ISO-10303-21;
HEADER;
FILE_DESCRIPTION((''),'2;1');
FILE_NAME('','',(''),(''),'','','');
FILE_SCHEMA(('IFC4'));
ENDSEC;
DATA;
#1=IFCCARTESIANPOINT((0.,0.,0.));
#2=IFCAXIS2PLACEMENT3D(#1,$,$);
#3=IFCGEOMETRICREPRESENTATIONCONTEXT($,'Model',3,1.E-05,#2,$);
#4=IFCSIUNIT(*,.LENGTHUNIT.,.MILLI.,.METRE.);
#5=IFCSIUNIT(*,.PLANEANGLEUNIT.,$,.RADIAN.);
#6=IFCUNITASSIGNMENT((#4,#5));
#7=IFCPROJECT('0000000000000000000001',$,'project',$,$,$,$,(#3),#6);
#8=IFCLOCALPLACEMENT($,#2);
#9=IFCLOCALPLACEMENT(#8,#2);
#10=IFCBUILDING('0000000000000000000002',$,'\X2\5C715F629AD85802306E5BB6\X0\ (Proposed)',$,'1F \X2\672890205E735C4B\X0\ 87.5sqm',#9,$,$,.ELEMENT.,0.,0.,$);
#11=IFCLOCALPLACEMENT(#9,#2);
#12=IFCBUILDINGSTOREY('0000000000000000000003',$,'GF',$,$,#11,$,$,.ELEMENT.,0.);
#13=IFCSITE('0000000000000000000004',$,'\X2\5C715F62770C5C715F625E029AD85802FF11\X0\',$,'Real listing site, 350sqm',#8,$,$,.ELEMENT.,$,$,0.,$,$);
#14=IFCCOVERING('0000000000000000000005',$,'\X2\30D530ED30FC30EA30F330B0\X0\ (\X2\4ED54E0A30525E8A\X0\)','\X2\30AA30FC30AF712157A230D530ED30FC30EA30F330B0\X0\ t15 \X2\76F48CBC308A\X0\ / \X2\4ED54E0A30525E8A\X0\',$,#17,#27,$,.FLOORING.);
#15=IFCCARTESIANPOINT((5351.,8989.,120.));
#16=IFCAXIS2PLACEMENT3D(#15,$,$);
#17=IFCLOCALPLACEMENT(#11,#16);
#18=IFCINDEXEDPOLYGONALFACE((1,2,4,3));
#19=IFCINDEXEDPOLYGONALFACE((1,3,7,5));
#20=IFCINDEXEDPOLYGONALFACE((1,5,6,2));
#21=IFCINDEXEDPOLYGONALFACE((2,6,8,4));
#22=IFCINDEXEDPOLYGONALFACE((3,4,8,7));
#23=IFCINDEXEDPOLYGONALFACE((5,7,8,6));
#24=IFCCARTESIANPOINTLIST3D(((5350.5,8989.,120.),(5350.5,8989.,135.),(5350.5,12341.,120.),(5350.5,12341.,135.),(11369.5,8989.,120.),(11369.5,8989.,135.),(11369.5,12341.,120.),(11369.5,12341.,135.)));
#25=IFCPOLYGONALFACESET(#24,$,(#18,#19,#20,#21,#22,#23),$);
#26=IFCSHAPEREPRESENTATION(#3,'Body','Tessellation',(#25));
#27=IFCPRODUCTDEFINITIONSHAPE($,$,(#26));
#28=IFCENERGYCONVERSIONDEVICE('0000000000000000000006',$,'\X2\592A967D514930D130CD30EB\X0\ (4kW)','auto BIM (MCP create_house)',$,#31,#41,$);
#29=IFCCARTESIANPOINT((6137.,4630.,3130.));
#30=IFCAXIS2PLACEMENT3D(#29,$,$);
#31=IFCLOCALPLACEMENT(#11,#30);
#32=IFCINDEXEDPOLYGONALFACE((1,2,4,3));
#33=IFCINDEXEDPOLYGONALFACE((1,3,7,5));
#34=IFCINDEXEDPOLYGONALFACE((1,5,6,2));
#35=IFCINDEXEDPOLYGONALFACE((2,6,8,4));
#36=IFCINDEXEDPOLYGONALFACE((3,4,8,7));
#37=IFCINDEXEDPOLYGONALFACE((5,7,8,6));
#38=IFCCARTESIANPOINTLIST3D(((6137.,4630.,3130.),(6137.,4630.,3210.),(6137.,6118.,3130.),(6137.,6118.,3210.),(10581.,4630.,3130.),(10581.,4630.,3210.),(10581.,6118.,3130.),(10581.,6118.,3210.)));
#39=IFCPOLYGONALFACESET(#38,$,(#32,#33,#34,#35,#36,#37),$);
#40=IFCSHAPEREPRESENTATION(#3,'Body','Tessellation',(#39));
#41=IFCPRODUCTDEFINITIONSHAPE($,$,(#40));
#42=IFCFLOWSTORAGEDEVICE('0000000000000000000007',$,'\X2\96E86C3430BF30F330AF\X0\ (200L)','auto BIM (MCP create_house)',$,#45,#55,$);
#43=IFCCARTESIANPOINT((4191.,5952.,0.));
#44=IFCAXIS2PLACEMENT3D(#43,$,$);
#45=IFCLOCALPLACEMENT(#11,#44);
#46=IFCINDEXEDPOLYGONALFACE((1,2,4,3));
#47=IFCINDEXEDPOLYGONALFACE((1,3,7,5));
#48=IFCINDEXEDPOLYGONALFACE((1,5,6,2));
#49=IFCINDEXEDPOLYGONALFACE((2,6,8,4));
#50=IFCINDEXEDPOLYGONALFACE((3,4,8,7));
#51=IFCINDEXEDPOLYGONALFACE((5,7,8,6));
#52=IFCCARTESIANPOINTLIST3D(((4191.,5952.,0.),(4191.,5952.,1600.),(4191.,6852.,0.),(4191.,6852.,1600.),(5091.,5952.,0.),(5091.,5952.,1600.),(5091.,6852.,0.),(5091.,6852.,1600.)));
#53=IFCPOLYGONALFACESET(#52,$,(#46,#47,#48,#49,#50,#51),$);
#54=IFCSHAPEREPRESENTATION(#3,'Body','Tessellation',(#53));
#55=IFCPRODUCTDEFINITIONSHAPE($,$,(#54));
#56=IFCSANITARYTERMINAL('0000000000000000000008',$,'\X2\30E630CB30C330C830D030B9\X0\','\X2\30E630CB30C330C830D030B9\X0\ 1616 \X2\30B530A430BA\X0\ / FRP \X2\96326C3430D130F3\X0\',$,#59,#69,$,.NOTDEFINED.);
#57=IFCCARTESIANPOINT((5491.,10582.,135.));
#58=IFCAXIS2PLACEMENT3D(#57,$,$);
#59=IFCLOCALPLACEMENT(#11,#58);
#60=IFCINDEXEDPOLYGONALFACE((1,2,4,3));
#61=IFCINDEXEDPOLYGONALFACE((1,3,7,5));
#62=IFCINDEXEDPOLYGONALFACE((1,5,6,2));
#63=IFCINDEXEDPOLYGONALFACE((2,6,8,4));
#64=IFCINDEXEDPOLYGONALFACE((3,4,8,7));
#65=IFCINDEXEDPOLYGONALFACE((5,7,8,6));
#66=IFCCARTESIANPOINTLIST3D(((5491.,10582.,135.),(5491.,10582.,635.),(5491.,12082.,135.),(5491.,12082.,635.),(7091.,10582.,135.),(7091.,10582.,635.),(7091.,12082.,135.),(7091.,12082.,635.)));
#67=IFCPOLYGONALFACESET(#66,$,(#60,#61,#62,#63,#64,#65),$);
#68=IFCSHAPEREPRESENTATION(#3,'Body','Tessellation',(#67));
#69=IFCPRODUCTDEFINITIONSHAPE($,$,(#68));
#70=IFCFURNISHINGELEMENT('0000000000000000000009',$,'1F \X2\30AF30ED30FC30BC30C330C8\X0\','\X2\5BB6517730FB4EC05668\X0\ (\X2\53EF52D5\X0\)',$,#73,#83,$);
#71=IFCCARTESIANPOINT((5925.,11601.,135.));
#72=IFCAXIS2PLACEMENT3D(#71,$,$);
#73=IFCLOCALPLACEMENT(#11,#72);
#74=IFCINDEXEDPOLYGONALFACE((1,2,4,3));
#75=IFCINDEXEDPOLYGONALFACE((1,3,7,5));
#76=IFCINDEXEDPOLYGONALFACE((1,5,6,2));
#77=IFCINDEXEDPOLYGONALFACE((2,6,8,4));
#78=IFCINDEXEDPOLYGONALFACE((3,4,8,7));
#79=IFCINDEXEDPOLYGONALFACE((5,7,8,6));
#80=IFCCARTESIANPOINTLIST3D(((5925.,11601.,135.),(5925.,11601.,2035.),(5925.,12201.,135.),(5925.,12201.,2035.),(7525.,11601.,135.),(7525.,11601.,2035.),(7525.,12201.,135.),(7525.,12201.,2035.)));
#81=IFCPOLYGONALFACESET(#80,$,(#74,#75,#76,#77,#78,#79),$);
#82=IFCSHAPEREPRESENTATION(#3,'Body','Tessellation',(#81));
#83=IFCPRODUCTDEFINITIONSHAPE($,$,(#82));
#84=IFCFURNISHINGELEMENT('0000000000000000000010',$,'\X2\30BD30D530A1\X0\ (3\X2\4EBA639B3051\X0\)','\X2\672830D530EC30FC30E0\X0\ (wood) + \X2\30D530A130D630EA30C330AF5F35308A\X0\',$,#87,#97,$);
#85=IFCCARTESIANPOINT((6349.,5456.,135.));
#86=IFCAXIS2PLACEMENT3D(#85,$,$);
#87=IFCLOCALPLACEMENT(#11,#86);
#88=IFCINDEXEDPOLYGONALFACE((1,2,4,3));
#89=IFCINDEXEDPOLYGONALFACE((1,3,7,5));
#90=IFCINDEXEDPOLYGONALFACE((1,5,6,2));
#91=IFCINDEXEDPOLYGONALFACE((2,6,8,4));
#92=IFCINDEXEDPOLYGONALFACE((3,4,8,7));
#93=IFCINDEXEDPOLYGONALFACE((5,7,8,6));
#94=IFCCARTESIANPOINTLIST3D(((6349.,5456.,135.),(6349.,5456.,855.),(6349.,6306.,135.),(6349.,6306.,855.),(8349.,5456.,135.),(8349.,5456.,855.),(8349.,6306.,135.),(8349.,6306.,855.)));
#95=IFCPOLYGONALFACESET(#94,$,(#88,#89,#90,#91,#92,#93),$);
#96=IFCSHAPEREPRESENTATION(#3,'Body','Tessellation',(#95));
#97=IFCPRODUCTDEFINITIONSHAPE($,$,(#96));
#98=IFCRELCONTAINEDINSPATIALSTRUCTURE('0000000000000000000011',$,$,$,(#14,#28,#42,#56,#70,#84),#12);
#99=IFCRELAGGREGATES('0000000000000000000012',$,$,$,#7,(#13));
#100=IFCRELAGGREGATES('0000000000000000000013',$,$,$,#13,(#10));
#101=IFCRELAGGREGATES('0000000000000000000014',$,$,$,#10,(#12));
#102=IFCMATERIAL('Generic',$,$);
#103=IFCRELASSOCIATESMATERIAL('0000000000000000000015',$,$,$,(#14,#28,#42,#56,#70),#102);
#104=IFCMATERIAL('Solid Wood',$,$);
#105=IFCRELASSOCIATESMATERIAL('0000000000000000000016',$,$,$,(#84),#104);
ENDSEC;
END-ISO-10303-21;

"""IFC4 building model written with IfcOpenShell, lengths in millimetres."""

from ifc_helpers import new_model, si_unit, frame, frame_2d, origin, place, context, project, spatial, rectangle, extrude, material, element, save


model = new_model("IFC4")

# Units and contexts
model_context = context("Model", 3, precision=1e-05, world=origin())
ifc_project = project(units=[si_unit("LENGTHUNIT", "METRE", prefix="MILLI"), si_unit("PLANEANGLEUNIT", "RADIAN")], contexts=[model_context])

# Site, building, storey
site_placement = place(None, origin())
site = spatial("IfcSite", under=ifc_project, at=site_placement, Name="山形県山形市高堂１", ObjectType="Real listing site, 350sqm", CompositionType="ELEMENT", RefElevation=0.0)
building_placement = place(site_placement, origin())
building = spatial("IfcBuilding", under=site, at=building_placement, Name="山形高堂の家 (Proposed)", ObjectType="1F 木造平屋 87.5sqm", CompositionType="ELEMENT", ElevationOfRefHeight=0.0, ElevationOfTerrain=0.0)
storey_placement = place(building_placement, origin())
storey = spatial("IfcBuildingStorey", under=building, at=storey_placement, Name="GF", CompositionType="ELEMENT", Elevation=0.0)

# Shared definitions
ifc_material_1 = material(Name="Solid Wood")

# Covering
ifc_material_2 = material(Name="Generic")
covering_1_placement = place(storey_placement, frame((5351.0, 8989.0, 120.0)))
element("IfcCovering", 1, at=covering_1_placement, inside=storey, material=ifc_material_2, Name="フローリング (仕上げ床)", Description="オーク無垢フローリング t15 直貼り / 仕上げ床", PredefinedType="FLOORING", context=model_context, shape_type="SweptSolid", body=[
    extrude(rectangle(XDim=6019.0, YDim=3352.0, at=frame_2d((3009.0, 1676.0))), frame((5351.0, 8989.0, 120.0)), (0.0, 0.0, 1.0), 15.0),
])

# Energy conversion device
energy_conversion_device_placement = place(storey_placement, frame((6137.0, 4630.0, 3130.0)))
element("IfcEnergyConversionDevice", 2, at=energy_conversion_device_placement, inside=storey, material=ifc_material_2, Name="太陽光パネル (4kW)", Description="auto BIM (MCP create_house)", context=model_context, shape_type="SweptSolid", body=[
    extrude(rectangle(XDim=4444.0, YDim=1488.0, at=frame_2d((2222.0, 744.0))), frame((6137.0, 4630.0, 3130.0)), (0.0, 0.0, 1.0), 80.0),
])

# Flow storage device
flow_storage_device_placement = place(storey_placement, frame((4191.0, 5952.0, 0.0)))
element("IfcFlowStorageDevice", 3, at=flow_storage_device_placement, inside=storey, material=ifc_material_2, Name="雨水タンク (200L)", Description="auto BIM (MCP create_house)", context=model_context, shape_type="SweptSolid", body=[
    extrude(rectangle(XDim=900.0, YDim=900.0, at=frame_2d((450.0, 450.0))), frame((4191.0, 5952.0, 0.0)), (0.0, 0.0, 1.0), 1600.0),
])

# Sanitary terminal
sanitary_terminal_placement = place(storey_placement, frame((5491.0, 10582.0, 135.0)))
element("IfcSanitaryTerminal", 4, at=sanitary_terminal_placement, inside=storey, material=ifc_material_2, Name="ユニットバス", Description="ユニットバス 1616 サイズ / FRP 防水パン", PredefinedType="NOTDEFINED", context=model_context, shape_type="SweptSolid", body=[
    extrude(rectangle(XDim=1600.0, YDim=1500.0, at=frame_2d((800.0, 750.0))), frame((5491.0, 10582.0, 135.0)), (0.0, 0.0, 1.0), 500.0),
])

# Furnishing elements
furnishing_1_placement = place(storey_placement, frame((5925.0, 11601.0, 135.0)))
element("IfcFurnishingElement", 5, at=furnishing_1_placement, inside=storey, material=ifc_material_2, Name="1F クローゼット", Description="家具・什器 (可動)", context=model_context, shape_type="SweptSolid", body=[
    extrude(rectangle(XDim=1600.0, YDim=600.0, at=frame_2d((800.0, 300.0))), frame((5925.0, 11601.0, 135.0)), (0.0, 0.0, 1.0), 1900.0),
])
furnishing_2_placement = place(storey_placement, frame((6349.0, 5456.0, 135.0)))
element("IfcFurnishingElement", 6, at=furnishing_2_placement, inside=storey, material=ifc_material_1, Name="ソファ (3人掛け)", Description="木フレーム (wood) + ファブリック張り", context=model_context, shape_type="SweptSolid", body=[
    extrude(rectangle(XDim=2000.0, YDim=850.0, at=frame_2d((1000.0, 425.0))), frame((6349.0, 5456.0, 135.0)), (0.0, 0.0, 1.0), 720.0),
])

save(model, "model.ifc")
